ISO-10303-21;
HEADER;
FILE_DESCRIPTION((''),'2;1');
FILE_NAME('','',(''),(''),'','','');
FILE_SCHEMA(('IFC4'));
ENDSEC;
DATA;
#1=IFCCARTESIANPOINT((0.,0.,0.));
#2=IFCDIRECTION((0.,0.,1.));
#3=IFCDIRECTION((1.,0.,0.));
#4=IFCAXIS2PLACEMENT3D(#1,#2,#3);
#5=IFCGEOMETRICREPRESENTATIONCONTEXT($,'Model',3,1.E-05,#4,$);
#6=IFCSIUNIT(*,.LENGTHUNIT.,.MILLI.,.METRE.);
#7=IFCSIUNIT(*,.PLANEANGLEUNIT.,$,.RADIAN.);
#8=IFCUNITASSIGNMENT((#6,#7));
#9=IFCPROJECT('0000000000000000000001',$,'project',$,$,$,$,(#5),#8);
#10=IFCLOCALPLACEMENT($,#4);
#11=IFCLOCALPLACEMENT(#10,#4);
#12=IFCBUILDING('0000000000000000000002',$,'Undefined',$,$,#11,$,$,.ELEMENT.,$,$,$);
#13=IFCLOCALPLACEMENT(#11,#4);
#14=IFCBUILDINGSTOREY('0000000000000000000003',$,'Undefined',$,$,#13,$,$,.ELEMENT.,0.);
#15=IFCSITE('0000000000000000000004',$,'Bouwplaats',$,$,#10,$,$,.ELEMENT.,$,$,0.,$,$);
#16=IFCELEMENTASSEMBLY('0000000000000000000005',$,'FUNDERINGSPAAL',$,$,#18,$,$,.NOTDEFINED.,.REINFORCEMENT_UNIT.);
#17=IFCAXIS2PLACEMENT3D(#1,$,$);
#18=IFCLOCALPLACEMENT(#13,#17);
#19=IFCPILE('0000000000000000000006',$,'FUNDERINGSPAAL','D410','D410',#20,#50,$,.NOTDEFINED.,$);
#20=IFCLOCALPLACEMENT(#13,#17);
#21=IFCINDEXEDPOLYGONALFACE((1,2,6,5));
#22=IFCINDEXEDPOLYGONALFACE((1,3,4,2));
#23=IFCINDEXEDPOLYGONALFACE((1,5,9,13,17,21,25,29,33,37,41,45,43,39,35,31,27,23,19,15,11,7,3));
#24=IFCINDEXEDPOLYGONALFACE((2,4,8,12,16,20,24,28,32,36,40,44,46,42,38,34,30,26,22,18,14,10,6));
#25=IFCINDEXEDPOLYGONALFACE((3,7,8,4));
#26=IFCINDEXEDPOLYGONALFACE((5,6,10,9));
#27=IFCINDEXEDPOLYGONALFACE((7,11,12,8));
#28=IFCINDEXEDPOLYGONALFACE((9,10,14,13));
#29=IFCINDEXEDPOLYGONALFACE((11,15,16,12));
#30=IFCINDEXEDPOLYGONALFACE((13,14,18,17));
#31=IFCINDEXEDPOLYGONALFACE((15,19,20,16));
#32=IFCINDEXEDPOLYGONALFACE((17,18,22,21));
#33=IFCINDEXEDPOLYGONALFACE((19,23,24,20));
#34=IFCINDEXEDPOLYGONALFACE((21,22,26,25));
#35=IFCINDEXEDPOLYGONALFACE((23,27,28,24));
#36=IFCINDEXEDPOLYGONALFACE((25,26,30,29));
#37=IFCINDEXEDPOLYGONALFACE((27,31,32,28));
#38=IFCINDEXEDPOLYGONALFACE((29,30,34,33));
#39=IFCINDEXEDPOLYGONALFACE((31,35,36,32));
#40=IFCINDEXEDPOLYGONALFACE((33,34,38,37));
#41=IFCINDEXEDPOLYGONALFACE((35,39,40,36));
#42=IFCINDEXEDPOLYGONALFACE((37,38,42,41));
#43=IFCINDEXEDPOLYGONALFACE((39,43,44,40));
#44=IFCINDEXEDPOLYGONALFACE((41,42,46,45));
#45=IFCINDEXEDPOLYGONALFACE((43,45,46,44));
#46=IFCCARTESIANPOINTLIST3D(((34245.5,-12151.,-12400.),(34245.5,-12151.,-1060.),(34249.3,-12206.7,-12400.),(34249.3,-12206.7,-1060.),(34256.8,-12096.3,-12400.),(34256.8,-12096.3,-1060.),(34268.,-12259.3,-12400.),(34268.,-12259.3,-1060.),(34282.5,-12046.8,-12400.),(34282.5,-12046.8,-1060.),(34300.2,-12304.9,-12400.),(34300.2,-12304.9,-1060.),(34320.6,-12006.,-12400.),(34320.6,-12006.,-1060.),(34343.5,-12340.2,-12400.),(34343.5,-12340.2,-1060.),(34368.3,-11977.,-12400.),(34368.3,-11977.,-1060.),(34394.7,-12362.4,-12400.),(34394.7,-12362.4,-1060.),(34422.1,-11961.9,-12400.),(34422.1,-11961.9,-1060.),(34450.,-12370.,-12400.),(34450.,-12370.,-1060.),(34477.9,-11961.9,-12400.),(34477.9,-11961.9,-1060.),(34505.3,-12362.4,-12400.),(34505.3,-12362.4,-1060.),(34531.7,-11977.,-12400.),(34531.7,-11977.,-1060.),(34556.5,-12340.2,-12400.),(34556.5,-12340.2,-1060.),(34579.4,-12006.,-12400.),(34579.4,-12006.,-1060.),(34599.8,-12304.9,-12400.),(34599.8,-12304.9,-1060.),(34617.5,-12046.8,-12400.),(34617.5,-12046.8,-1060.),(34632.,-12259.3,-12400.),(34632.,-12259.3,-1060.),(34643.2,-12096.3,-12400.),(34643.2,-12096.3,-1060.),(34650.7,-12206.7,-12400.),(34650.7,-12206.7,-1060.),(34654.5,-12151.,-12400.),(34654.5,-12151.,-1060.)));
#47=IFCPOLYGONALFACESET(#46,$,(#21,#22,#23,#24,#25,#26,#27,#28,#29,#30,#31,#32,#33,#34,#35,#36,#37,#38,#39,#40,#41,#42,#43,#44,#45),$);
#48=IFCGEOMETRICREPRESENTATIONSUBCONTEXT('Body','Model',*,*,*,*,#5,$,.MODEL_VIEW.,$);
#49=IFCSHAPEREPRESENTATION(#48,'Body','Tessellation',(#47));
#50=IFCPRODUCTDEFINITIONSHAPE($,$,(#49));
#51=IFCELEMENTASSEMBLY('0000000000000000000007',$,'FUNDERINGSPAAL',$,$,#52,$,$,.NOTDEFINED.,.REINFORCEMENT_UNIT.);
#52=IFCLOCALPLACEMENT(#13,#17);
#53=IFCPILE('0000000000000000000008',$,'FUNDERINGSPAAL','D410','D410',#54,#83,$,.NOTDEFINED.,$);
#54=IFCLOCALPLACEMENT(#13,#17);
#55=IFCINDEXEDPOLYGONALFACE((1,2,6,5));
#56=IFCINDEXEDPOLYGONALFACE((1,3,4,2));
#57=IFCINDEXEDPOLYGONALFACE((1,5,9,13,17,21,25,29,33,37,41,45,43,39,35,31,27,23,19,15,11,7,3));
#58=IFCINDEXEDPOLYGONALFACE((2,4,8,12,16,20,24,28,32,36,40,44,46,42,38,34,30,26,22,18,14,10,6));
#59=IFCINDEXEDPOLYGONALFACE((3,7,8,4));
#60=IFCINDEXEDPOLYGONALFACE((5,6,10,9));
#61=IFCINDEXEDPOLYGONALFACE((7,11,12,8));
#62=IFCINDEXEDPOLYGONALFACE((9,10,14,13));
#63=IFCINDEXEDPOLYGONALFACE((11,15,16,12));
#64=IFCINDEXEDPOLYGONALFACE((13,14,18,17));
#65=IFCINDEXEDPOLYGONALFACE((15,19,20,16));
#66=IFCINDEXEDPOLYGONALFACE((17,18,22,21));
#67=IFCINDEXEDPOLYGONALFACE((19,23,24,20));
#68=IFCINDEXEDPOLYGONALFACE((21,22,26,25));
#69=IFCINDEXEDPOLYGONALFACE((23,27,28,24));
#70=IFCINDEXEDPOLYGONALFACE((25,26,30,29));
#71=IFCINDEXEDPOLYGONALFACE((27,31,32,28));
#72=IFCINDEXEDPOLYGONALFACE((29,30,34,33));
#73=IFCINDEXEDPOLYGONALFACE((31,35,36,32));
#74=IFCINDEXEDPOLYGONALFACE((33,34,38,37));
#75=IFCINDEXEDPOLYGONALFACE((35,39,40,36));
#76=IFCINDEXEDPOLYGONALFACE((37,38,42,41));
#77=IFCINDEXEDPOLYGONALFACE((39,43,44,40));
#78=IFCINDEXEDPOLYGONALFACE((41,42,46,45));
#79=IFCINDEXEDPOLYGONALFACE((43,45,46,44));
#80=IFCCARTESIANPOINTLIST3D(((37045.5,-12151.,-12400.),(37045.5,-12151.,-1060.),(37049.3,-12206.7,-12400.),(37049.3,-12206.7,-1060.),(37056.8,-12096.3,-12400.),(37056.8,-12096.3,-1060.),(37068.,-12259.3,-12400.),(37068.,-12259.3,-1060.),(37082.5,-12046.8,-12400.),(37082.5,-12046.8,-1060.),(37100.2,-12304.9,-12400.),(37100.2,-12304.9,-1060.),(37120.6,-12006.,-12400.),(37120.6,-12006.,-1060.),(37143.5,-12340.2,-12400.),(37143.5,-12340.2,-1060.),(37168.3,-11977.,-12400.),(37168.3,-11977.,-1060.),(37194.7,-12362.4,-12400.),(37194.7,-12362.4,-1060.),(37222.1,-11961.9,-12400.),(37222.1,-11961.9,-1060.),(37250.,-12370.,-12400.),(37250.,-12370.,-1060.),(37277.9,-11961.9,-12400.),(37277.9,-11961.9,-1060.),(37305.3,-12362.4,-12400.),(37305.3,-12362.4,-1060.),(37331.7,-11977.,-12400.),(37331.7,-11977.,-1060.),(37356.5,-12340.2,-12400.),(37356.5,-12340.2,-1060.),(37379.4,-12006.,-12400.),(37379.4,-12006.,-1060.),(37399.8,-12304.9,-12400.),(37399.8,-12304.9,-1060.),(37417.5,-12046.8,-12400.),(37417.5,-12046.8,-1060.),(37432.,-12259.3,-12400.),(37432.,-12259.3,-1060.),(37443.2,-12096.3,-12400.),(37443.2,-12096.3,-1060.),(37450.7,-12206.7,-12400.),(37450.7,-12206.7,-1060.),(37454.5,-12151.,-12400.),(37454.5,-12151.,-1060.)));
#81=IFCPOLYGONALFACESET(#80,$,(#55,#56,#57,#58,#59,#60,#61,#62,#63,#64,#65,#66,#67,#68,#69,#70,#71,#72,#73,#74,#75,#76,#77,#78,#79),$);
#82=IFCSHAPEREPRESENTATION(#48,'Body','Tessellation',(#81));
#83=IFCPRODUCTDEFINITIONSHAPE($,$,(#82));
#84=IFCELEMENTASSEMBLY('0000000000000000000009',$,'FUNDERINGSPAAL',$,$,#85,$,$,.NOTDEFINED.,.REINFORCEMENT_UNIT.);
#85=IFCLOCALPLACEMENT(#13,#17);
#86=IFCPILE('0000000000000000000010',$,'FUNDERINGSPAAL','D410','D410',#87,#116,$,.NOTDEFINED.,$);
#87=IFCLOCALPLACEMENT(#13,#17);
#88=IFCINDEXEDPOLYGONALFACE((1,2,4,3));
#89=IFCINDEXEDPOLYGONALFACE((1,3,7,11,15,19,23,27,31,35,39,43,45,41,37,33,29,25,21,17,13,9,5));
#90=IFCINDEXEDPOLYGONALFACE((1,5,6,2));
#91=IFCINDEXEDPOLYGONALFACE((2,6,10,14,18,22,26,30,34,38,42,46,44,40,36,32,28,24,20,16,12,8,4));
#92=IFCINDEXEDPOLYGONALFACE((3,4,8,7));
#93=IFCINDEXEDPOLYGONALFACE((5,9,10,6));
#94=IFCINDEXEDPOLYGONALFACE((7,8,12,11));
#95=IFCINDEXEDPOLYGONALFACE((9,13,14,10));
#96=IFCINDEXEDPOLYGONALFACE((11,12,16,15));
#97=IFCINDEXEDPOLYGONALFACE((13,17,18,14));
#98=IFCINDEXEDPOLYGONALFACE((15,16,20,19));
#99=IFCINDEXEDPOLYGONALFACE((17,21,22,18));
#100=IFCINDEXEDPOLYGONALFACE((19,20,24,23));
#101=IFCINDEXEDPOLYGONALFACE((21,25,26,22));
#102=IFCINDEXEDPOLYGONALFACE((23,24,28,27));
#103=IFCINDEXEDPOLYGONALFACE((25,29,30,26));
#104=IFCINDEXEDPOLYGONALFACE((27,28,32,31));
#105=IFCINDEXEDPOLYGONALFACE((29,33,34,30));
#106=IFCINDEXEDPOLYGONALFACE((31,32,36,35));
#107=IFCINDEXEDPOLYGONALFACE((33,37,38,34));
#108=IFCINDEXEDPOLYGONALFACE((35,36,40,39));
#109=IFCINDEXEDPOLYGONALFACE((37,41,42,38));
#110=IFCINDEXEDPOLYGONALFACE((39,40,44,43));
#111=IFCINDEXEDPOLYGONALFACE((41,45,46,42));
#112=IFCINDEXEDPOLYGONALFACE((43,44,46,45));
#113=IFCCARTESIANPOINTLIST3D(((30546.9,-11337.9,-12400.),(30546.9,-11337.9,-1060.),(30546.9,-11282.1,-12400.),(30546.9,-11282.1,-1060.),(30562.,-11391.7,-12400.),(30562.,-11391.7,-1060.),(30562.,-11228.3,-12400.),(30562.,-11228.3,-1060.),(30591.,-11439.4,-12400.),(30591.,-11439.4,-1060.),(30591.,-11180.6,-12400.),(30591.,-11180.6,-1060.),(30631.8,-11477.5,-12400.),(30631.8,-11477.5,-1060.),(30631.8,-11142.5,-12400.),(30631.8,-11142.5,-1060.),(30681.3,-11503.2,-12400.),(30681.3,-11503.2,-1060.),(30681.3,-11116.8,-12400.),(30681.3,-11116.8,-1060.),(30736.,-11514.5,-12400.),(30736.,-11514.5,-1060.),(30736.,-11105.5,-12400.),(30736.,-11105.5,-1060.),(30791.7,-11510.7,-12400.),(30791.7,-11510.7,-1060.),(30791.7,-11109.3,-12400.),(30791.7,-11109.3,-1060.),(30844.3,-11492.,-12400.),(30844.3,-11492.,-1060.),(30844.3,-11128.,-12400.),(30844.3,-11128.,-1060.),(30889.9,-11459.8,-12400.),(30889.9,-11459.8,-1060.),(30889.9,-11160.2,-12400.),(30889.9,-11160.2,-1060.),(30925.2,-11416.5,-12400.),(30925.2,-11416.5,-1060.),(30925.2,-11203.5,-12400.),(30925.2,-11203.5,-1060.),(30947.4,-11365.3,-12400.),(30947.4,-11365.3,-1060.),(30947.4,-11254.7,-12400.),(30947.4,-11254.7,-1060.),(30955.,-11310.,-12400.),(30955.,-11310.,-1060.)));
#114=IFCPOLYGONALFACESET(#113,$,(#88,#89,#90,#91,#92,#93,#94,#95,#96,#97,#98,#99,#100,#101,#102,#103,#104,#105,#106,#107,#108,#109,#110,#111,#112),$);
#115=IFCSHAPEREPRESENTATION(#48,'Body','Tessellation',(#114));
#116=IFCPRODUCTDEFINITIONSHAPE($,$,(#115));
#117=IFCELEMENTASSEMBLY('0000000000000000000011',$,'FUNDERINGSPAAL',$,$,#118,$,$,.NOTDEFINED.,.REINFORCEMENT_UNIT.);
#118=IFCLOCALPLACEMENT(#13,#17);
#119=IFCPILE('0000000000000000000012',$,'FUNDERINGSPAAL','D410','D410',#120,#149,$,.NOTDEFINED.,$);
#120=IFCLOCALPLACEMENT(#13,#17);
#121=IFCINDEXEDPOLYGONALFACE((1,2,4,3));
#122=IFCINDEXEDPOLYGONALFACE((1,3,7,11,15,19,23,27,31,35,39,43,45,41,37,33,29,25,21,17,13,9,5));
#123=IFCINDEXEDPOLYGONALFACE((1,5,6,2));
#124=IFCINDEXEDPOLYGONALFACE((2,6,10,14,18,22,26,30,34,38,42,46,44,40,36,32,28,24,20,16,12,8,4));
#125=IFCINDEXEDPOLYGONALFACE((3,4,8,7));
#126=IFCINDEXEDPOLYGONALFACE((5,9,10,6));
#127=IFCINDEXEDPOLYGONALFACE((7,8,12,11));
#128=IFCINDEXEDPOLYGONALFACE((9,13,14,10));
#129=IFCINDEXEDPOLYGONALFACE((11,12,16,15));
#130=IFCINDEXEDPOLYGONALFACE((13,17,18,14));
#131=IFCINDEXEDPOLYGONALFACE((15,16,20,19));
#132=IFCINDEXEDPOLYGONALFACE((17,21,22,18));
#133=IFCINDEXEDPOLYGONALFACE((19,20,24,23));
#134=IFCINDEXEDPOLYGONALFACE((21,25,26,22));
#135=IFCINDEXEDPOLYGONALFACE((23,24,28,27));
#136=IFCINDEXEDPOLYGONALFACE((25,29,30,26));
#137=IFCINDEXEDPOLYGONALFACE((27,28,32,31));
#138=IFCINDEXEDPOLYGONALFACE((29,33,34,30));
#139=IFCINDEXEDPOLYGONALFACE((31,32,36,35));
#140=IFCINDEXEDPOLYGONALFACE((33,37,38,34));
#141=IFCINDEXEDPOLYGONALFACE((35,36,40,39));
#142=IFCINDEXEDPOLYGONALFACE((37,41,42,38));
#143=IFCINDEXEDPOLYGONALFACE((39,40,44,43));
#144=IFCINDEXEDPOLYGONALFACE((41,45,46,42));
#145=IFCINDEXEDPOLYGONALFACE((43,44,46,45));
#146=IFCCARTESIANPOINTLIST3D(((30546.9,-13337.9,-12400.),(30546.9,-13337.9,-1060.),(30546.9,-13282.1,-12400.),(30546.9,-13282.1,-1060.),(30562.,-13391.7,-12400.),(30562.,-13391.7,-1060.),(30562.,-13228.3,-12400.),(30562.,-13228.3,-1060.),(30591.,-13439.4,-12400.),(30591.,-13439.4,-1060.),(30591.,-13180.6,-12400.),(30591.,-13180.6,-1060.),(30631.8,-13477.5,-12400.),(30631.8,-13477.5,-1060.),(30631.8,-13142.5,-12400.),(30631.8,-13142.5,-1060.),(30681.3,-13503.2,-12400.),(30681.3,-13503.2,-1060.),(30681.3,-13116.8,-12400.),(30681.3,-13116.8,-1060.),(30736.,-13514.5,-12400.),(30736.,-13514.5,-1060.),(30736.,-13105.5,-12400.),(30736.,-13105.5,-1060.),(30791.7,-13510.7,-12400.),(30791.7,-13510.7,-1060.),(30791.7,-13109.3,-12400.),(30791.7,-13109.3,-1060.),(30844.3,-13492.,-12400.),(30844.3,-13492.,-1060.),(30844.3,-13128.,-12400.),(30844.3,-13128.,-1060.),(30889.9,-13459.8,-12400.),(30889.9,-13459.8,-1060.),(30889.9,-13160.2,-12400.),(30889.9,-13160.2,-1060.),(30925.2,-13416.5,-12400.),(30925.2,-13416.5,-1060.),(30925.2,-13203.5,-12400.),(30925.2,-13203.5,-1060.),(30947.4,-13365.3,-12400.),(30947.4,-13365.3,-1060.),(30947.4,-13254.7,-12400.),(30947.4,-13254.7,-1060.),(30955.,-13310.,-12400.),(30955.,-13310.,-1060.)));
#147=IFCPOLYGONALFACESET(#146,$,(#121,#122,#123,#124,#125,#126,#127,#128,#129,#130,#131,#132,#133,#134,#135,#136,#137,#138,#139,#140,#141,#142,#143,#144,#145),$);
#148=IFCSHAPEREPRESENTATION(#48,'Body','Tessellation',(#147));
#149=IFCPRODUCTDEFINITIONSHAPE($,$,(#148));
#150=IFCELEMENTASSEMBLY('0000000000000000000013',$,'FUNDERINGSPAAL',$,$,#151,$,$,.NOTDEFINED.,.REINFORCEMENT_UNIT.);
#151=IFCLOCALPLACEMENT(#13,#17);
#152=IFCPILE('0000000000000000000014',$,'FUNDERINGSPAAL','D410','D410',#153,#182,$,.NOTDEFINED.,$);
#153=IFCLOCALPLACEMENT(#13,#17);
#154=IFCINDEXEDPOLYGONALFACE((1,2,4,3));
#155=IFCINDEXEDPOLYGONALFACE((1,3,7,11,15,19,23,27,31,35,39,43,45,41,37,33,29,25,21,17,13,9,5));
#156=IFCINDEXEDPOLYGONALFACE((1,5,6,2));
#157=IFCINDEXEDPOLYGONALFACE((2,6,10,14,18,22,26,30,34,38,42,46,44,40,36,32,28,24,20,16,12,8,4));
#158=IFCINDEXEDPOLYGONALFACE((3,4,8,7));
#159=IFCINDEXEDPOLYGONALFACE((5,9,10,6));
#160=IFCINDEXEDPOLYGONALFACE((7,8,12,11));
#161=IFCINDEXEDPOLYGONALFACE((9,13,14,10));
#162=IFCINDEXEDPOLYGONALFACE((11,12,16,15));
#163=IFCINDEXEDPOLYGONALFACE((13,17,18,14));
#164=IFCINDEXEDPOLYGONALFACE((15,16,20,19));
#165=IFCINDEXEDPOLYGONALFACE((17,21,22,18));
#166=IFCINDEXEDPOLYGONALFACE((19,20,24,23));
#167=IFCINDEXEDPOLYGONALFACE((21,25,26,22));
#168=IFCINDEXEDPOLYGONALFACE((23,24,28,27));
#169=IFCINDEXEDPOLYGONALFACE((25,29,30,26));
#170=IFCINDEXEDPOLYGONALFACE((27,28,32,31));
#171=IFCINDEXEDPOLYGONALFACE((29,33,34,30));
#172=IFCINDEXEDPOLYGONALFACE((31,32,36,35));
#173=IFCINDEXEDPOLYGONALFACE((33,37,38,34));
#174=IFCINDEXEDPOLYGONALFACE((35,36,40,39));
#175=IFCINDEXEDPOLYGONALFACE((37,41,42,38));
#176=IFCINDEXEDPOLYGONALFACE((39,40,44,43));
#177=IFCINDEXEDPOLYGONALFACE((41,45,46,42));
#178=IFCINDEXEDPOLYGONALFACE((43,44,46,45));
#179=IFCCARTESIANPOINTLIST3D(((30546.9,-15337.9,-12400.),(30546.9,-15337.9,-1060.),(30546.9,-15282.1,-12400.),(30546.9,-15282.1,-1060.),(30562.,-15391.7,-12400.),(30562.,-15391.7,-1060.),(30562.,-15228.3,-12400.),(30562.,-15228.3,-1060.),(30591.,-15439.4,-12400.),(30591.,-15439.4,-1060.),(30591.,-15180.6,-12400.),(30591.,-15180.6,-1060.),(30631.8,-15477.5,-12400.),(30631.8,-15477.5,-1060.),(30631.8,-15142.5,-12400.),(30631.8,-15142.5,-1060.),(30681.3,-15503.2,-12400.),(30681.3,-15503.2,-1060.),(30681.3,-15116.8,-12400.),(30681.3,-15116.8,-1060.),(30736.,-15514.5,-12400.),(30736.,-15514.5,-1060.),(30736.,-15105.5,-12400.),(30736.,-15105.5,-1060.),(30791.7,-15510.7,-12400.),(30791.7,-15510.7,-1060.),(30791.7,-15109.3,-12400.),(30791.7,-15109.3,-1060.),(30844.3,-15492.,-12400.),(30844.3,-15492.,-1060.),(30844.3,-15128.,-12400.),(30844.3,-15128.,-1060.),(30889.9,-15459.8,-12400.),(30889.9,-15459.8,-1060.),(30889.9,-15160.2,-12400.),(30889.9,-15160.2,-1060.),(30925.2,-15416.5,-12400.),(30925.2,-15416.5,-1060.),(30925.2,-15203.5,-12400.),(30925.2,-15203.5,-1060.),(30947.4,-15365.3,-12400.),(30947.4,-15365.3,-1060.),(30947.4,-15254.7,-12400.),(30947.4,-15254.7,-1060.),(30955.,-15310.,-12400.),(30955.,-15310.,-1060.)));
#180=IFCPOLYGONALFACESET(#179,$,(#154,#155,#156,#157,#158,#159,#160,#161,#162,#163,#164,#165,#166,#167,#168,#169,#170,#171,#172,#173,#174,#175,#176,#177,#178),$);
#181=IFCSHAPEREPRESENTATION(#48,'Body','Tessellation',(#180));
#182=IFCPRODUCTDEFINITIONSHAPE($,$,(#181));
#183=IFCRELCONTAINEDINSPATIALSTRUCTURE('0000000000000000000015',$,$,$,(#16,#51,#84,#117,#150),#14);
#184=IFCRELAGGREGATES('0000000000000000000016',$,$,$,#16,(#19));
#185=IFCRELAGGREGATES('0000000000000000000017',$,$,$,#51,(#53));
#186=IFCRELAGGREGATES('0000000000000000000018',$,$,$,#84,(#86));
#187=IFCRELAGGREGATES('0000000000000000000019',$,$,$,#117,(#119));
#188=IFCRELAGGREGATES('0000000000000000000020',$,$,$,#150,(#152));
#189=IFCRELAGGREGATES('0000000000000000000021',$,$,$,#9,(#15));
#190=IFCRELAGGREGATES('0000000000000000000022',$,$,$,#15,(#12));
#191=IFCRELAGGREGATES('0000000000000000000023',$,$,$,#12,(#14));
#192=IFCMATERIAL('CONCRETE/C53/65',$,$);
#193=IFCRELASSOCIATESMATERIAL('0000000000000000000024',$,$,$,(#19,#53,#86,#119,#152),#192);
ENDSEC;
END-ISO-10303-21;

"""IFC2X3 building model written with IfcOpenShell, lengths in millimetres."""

from ifc_helpers import new_model, si_unit, frame, origin_with_axes, origin_2d_with_axis, place, context, subcontext, project, spatial, circle, extrude, clip, halfspace, material, element, aggregate, save


model = new_model("IFC2X3")

# Units and contexts
model_context = context("Model", 3, precision=1e-05, world=origin_with_axes())
body_context = subcontext(model_context, "Body", "Model", "MODEL_VIEW")
ifc_project = project(units=[si_unit("LENGTHUNIT", "METRE", prefix="MILLI"), si_unit("PLANEANGLEUNIT", "RADIAN")], contexts=[model_context])

# Site, building, storey
site_placement = place(None, origin_with_axes())
site = spatial("IfcSite", under=ifc_project, at=site_placement, Name="Bouwplaats", CompositionType="ELEMENT", RefElevation=0.0)
building_placement = place(site_placement, origin_with_axes())
building = spatial("IfcBuilding", under=site, at=building_placement, Name="Undefined", CompositionType="ELEMENT")
storey_placement = place(building_placement, origin_with_axes())
storey = spatial("IfcBuildingStorey", under=building, at=storey_placement, Name="Undefined", CompositionType="ELEMENT", Elevation=0.0)

# Element assemblies, piles
assembly_1_placement = place(storey_placement, origin_with_axes())
assembly_1 = element("IfcElementAssembly", 1, at=assembly_1_placement, inside=storey, Name="FUNDERINGSPAAL", AssemblyPlace="NOTDEFINED", PredefinedType="REINFORCEMENT_UNIT")
ifc_material_1 = material(Name="CONCRETE/C53/65")
pile_1_placement = place(assembly_1_placement, frame((34450.0, -12165.0, -1060.0), z_axis=(1.0, 0.0, 0.0), x_axis=(0.0, 0.0, -1.0)))
pile_1 = element("IfcPile", 2, at=pile_1_placement, material=ifc_material_1, Name="FUNDERINGSPAAL", Description="D410", ObjectType="D410", PredefinedType="NOTDEFINED", context=body_context, shape_type="Clipping", body=[
    clip(extrude(circle(Radius=205.0, at=origin_2d_with_axis()), frame((11340.0, 0.0, 0.0), z_axis=(-1.0, 0.0, 0.0), x_axis=(0.0, -1.0, 0.0)), (0.0, 0.0, 1.0), 11340.0), halfspace(frame((0.0, 205.0, -205.0), z_axis=(-1.0, 0.0, 0.0), x_axis=(0.0, 0.0, 1.0)), False)),
])
aggregate(assembly_1, [pile_1])
assembly_2_placement = place(storey_placement, origin_with_axes())
assembly_2 = element("IfcElementAssembly", 3, at=assembly_2_placement, inside=storey, Name="FUNDERINGSPAAL", AssemblyPlace="NOTDEFINED", PredefinedType="REINFORCEMENT_UNIT")
pile_2_placement = place(assembly_2_placement, frame((37250.0, -12165.0, -1060.0), z_axis=(1.0, 0.0, 0.0), x_axis=(0.0, 0.0, -1.0)))
pile_2 = element("IfcPile", 4, at=pile_2_placement, material=ifc_material_1, Name="FUNDERINGSPAAL", Description="D410", ObjectType="D410", PredefinedType="NOTDEFINED", context=body_context, shape_type="Clipping", body=[
    clip(extrude(circle(Radius=205.0, at=origin_2d_with_axis()), frame((11340.0, 0.0, 0.0), z_axis=(-1.0, 0.0, 0.0), x_axis=(0.0, -1.0, 0.0)), (0.0, 0.0, 1.0), 11340.0), halfspace(frame((0.0, 205.0, -205.0), z_axis=(-1.0, 0.0, 0.0), x_axis=(0.0, 0.0, 1.0)), False)),
])
aggregate(assembly_2, [pile_2])
assembly_3_placement = place(storey_placement, origin_with_axes())
assembly_3 = element("IfcElementAssembly", 5, at=assembly_3_placement, inside=storey, Name="FUNDERINGSPAAL", AssemblyPlace="NOTDEFINED", PredefinedType="REINFORCEMENT_UNIT")
pile_3_placement = place(assembly_3_placement, frame((30750.0, -11310.0, -1060.0), z_axis=(0.0, 1.0, 0.0), x_axis=(0.0, 0.0, -1.0)))
pile_3 = element("IfcPile", 6, at=pile_3_placement, material=ifc_material_1, Name="FUNDERINGSPAAL", Description="D410", ObjectType="D410", PredefinedType="NOTDEFINED", context=body_context, shape_type="Clipping", body=[
    clip(extrude(circle(Radius=205.0, at=origin_2d_with_axis()), frame((11340.0, 0.0, 0.0), z_axis=(-1.0, 0.0, 0.0), x_axis=(0.0, -1.0, 0.0)), (0.0, 0.0, 1.0), 11340.0), halfspace(frame((0.0, 205.0, -205.0), z_axis=(-1.0, 0.0, 0.0), x_axis=(0.0, 0.0, 1.0)), False)),
])
aggregate(assembly_3, [pile_3])
assembly_4_placement = place(storey_placement, origin_with_axes())
assembly_4 = element("IfcElementAssembly", 7, at=assembly_4_placement, inside=storey, Name="FUNDERINGSPAAL", AssemblyPlace="NOTDEFINED", PredefinedType="REINFORCEMENT_UNIT")
pile_4_placement = place(assembly_4_placement, frame((30750.0, -13310.0, -1060.0), z_axis=(0.0, 1.0, 0.0), x_axis=(0.0, 0.0, -1.0)))
pile_4 = element("IfcPile", 8, at=pile_4_placement, material=ifc_material_1, Name="FUNDERINGSPAAL", Description="D410", ObjectType="D410", PredefinedType="NOTDEFINED", context=body_context, shape_type="Clipping", body=[
    clip(extrude(circle(Radius=205.0, at=origin_2d_with_axis()), frame((11340.0, 0.0, 0.0), z_axis=(-1.0, 0.0, 0.0), x_axis=(0.0, -1.0, 0.0)), (0.0, 0.0, 1.0), 11340.0), halfspace(frame((0.0, 205.0, -205.0), z_axis=(-1.0, 0.0, 0.0), x_axis=(0.0, 0.0, 1.0)), False)),
])
aggregate(assembly_4, [pile_4])
assembly_5_placement = place(storey_placement, origin_with_axes())
assembly_5 = element("IfcElementAssembly", 9, at=assembly_5_placement, inside=storey, Name="FUNDERINGSPAAL", AssemblyPlace="NOTDEFINED", PredefinedType="REINFORCEMENT_UNIT")
pile_5_placement = place(assembly_5_placement, frame((30750.0, -15310.0, -1060.0), z_axis=(0.0, 1.0, 0.0), x_axis=(0.0, 0.0, -1.0)))
pile_5 = element("IfcPile", 10, at=pile_5_placement, material=ifc_material_1, Name="FUNDERINGSPAAL", Description="D410", ObjectType="D410", PredefinedType="NOTDEFINED", context=body_context, shape_type="Clipping", body=[
    clip(extrude(circle(Radius=205.0, at=origin_2d_with_axis()), frame((11340.0, 0.0, 0.0), z_axis=(-1.0, 0.0, 0.0), x_axis=(0.0, -1.0, 0.0)), (0.0, 0.0, 1.0), 11340.0), halfspace(frame((0.0, 205.0, -205.0), z_axis=(-1.0, 0.0, 0.0), x_axis=(0.0, 0.0, 1.0)), False)),
])
aggregate(assembly_5, [pile_5])

save(model, "model.ifc")
